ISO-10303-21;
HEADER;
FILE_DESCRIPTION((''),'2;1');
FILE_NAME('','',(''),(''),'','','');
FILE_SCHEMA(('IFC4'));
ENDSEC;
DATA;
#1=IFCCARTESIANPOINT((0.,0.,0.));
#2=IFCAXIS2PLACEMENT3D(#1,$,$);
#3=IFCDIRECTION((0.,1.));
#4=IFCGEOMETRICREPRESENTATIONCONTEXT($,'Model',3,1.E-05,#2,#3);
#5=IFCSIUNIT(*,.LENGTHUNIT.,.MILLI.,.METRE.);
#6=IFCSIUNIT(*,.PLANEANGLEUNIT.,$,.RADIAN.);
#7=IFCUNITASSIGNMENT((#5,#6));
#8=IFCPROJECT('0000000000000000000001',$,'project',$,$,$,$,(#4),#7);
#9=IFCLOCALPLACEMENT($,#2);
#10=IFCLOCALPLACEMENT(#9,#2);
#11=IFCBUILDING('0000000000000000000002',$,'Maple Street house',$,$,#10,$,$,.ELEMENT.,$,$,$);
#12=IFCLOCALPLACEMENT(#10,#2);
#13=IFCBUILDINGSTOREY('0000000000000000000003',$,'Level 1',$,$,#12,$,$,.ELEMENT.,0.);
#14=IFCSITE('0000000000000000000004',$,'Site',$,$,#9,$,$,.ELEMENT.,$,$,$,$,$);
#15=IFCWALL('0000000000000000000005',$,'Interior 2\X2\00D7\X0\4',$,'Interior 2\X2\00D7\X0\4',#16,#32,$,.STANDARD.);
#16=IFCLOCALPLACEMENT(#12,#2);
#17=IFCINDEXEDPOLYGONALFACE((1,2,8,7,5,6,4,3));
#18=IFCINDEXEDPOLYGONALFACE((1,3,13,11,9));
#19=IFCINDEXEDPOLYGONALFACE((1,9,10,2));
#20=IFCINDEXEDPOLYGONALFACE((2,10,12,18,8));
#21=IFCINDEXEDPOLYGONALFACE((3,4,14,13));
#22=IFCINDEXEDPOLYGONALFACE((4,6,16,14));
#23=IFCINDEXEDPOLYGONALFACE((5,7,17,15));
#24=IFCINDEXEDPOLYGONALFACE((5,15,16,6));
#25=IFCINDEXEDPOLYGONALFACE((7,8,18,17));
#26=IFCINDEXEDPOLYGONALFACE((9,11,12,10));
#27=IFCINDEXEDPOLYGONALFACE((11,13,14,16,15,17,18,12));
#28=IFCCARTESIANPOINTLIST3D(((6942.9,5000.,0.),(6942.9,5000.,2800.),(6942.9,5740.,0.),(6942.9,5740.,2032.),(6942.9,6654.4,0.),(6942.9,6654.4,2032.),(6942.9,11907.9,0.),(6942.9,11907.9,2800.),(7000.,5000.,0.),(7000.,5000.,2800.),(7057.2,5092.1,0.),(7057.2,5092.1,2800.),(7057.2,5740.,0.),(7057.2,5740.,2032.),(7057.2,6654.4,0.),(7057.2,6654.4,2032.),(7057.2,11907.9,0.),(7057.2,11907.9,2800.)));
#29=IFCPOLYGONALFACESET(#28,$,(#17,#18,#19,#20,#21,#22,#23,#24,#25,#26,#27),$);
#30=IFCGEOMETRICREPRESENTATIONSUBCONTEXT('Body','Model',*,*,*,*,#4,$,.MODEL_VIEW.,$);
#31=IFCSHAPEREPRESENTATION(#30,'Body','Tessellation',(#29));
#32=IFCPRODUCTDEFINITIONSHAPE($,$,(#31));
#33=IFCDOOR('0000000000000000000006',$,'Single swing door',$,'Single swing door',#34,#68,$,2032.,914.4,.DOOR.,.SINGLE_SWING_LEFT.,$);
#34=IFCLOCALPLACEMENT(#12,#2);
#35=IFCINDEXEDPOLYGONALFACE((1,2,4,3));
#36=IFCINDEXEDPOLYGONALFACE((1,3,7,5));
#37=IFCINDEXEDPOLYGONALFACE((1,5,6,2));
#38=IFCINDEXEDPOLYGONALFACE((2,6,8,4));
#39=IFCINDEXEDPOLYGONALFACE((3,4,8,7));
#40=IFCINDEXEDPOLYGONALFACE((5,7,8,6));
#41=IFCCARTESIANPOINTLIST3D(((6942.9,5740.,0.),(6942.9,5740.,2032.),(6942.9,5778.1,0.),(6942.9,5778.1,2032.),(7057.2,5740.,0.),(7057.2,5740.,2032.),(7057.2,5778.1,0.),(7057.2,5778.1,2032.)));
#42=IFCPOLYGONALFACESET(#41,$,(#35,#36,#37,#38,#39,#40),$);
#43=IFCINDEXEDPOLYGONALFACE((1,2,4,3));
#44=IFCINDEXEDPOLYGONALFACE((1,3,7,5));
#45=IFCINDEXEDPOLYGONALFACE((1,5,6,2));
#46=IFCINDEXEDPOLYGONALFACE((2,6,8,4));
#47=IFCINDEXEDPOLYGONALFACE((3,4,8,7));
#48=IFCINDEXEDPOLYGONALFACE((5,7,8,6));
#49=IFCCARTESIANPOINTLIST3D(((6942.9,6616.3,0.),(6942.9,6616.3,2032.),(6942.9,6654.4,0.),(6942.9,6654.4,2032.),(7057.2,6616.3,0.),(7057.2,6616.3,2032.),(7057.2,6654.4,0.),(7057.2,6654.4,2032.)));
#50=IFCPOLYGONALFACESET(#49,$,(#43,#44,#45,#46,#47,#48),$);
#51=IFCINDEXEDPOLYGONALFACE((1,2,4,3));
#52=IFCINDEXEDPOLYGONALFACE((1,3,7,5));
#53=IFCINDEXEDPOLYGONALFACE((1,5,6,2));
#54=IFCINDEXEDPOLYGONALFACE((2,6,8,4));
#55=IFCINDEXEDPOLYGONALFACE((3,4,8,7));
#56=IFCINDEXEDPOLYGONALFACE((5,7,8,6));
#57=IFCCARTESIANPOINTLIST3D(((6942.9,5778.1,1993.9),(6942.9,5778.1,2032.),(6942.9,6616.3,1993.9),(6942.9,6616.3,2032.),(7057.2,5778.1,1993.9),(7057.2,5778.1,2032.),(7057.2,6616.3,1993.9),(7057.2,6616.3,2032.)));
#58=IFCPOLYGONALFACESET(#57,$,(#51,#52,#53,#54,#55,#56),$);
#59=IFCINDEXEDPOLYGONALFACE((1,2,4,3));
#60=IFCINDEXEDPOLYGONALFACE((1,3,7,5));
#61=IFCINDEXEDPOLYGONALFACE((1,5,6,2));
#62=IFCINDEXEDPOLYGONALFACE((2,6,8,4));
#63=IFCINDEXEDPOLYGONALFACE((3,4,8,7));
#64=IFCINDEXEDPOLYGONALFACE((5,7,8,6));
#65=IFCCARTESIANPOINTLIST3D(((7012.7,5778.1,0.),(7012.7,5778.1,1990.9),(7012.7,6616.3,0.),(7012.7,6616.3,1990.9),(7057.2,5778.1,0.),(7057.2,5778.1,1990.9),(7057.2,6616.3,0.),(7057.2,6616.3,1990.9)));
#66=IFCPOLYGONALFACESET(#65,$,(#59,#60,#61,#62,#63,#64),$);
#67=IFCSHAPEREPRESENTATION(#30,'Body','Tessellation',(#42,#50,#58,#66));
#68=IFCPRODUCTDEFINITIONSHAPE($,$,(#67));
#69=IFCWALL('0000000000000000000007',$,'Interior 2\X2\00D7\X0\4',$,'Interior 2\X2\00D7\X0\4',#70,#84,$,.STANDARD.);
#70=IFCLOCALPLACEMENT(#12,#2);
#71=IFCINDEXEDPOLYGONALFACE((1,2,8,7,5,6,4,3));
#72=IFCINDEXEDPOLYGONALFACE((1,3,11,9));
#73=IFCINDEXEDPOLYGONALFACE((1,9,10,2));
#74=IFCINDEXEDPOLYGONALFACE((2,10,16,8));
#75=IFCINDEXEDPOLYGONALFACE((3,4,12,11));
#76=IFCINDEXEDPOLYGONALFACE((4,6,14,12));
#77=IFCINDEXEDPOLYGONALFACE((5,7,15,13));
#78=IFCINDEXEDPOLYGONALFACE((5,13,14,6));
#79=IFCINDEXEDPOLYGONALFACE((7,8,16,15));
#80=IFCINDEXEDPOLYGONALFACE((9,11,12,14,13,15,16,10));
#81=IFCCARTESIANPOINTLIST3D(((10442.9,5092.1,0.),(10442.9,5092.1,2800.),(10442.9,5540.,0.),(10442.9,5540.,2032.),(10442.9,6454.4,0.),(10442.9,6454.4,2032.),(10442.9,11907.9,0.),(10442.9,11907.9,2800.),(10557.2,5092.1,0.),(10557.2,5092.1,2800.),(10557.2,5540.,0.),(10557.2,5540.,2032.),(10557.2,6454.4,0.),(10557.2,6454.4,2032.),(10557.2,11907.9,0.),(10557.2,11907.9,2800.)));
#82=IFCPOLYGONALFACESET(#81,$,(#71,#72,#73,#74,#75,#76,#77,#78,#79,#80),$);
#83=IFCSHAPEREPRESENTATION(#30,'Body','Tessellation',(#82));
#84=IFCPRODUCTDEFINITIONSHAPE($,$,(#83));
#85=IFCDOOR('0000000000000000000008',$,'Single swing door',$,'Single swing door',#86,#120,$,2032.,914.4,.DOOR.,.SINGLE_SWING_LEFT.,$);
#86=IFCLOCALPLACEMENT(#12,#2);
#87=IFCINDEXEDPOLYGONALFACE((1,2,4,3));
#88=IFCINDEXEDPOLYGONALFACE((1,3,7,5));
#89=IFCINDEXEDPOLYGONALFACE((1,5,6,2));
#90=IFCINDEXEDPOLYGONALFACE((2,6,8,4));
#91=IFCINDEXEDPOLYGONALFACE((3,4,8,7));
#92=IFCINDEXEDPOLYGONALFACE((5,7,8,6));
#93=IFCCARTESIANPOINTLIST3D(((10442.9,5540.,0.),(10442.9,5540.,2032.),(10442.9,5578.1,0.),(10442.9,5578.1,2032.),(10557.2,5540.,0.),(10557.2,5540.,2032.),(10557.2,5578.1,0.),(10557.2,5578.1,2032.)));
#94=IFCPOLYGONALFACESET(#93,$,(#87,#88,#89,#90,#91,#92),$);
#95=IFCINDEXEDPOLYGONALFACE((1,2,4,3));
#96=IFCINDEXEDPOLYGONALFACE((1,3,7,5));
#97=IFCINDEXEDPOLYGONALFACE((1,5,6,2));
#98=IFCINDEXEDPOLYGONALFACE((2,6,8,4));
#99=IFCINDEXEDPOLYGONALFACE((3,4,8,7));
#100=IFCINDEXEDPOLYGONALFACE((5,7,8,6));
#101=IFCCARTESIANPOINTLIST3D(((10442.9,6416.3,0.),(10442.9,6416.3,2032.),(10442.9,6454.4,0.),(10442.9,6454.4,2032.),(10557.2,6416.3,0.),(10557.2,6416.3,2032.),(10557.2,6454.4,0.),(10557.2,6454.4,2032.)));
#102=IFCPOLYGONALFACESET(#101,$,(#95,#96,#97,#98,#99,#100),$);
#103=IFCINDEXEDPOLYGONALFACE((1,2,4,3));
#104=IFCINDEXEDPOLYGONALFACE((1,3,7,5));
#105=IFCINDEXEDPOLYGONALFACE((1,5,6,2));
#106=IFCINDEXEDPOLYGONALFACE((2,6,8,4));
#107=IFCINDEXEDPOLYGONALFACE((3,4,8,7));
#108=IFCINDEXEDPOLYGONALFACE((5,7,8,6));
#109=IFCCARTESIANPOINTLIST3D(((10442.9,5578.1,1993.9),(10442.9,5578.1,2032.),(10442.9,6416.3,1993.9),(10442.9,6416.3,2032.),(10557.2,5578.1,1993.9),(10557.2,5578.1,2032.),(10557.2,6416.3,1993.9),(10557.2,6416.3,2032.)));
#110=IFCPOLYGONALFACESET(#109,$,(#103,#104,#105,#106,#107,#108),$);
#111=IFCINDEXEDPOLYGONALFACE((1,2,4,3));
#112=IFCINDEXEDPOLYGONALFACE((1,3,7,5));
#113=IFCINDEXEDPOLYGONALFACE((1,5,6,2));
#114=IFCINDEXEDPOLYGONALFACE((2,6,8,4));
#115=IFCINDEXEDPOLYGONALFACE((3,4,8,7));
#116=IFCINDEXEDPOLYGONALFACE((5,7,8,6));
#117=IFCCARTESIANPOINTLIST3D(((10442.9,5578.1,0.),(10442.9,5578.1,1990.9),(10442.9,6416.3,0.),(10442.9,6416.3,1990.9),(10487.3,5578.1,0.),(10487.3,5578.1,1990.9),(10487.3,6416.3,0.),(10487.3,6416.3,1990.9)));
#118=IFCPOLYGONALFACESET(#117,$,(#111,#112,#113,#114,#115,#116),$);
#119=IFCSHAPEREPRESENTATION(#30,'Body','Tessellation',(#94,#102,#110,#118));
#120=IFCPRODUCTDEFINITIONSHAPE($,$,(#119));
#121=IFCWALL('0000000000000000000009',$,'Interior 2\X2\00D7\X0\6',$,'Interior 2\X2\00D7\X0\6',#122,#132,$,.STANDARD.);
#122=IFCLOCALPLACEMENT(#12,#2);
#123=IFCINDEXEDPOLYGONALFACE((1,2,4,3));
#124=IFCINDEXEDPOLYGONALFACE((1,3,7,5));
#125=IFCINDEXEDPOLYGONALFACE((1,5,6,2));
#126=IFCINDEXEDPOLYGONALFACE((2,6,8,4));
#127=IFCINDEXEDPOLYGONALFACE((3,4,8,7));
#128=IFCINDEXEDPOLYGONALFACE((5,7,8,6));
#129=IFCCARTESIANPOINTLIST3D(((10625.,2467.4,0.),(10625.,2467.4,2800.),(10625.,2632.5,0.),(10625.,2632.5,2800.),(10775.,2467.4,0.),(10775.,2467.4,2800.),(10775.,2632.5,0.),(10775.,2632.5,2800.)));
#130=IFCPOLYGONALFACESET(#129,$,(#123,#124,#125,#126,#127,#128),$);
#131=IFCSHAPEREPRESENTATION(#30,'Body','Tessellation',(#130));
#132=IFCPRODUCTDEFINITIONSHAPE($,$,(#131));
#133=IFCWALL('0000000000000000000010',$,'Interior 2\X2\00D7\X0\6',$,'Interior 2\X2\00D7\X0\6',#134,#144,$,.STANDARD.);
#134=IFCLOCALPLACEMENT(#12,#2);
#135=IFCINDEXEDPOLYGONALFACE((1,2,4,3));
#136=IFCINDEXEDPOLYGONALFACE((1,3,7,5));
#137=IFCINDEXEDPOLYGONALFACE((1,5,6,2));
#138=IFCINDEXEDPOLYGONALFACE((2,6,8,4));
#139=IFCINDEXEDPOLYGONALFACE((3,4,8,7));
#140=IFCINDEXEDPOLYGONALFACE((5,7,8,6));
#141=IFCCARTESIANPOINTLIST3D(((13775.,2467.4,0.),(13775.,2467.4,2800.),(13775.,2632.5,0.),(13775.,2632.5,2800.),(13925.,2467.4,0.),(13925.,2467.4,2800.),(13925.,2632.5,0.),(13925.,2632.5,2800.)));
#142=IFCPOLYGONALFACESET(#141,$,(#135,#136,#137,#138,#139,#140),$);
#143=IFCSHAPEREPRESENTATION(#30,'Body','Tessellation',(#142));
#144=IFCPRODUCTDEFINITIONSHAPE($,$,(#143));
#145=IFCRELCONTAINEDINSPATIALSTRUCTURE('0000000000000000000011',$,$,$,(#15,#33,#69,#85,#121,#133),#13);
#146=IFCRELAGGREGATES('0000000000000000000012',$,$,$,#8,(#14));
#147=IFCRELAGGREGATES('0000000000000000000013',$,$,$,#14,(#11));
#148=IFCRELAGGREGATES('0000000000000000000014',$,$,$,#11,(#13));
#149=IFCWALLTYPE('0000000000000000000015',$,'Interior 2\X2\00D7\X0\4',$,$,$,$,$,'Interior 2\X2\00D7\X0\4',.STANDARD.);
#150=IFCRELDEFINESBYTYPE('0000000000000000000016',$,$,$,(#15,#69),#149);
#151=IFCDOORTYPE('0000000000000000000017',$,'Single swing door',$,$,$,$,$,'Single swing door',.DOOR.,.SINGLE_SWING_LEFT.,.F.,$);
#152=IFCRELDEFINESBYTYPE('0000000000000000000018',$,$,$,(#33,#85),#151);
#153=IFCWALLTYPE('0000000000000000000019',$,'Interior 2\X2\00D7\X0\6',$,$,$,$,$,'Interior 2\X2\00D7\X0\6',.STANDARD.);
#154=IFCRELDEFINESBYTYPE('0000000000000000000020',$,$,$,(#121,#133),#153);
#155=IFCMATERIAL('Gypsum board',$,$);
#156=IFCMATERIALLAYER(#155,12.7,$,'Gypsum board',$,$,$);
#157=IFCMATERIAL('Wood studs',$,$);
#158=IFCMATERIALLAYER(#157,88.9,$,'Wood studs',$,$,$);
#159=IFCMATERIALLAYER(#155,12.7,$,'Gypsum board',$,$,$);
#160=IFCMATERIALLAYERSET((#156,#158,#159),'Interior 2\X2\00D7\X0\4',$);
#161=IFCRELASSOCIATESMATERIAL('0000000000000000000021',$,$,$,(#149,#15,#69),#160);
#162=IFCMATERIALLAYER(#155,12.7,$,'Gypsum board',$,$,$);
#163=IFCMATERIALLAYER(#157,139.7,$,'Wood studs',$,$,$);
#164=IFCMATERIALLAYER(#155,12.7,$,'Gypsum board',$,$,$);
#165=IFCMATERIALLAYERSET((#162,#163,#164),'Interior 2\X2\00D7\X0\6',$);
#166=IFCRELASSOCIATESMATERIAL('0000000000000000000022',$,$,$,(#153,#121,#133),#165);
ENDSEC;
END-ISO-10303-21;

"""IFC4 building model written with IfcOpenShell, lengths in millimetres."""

from ifc_helpers import new_model, si_unit, direction, frame, origin, origin_with_axes, place, context, subcontext, project, spatial, polyline, outline, extrude, material, layer, layer_set, layer_usage, type_object, element, fill, save


model = new_model("IFC4")

# Units and contexts
model_context = context("Model", 3, precision=1e-05, world=origin(), true_north=direction((0.0, 1.0)))
body_context = subcontext(model_context, "Body", "Model", "MODEL_VIEW")
ifc_project = project(units=[si_unit("LENGTHUNIT", "METRE", prefix="MILLI"), si_unit("PLANEANGLEUNIT", "RADIAN")], contexts=[model_context])

# Site, building, storey
site_placement = place(None, origin())
site = spatial("IfcSite", under=ifc_project, at=site_placement, Name="Site", CompositionType="ELEMENT")
building_placement = place(site_placement, origin())
building = spatial("IfcBuilding", under=site, at=building_placement, Name="Maple Street house", CompositionType="ELEMENT")
storey_placement = place(building_placement, origin())
storey = spatial("IfcBuildingStorey", under=building, at=storey_placement, Name="Level 1", CompositionType="ELEMENT", Elevation=0.0)

# Shared definitions
ifc_material_1 = material(Name="Wood studs")
ifc_material_2 = material(Name="Gypsum board")

# Walls, openings, doors
ifc_layer_1 = layer(ifc_material_2, 12.7, Name="Gypsum board")
ifc_layer_2 = layer(ifc_material_1, 88.9, Name="Wood studs")
ifc_layer_3 = layer(ifc_material_2, 12.7, Name="Gypsum board")
ifc_layer_set_1 = layer_set([ifc_layer_1, ifc_layer_2, ifc_layer_3], Name="Interior 2×4")
ifc_layer_usage_1 = layer_usage(ifc_layer_set_1, "AXIS2", "NEGATIVE", 57.1)
wall_type_1 = type_object("IfcWallType", Name="Interior 2×4", ElementType="Interior 2×4", PredefinedType="STANDARD", material=ifc_layer_set_1)
wall_1_placement = place(storey_placement, frame((7000.0, 5000.0, 0.0), z_axis=(0.0, 0.0, 1.0), x_axis=(0.0, 1.0, 0.0)))
wall_1 = element("IfcWall", 1, at=wall_1_placement, inside=storey, type_object=wall_type_1, material=ifc_layer_usage_1, Name="Interior 2×4", ObjectType="Interior 2×4", PredefinedType="STANDARD", context=body_context, shape_type="SweptSolid", body=[
    extrude(outline(polyline([(92.1, -57.1), (6907.9, -57.1), (6907.9, 57.1), (0.0, 57.1), (0.0, 0.0), (92.1, -57.1)])), origin(), (0.0, 0.0, 1.0), 2800.0),
])
opening_1_placement = place(wall_1_placement, frame((740.0, 0.0, 0.0), z_axis=(0.0, 0.0, 1.0), x_axis=(1.0, 0.0, 0.0)))
opening_1 = element("IfcOpeningElement", 2, at=opening_1_placement, cuts=wall_1, PredefinedType="OPENING", context=body_context, shape_type="SweptSolid", body=[
    extrude(outline(polyline([(0.0, -67.2), (914.4, -67.2), (914.4, 67.2), (0.0, 67.2), (0.0, -67.2)])), origin(), (0.0, 0.0, 1.0), 2032.0),
])
door_type_1 = type_object("IfcDoorType", Name="Single swing door", ElementType="Single swing door", OperationType="SINGLE_SWING_LEFT", ParameterTakesPrecedence=False, PredefinedType="DOOR")
door_1_placement = place(opening_1_placement, origin_with_axes())
door_1 = element("IfcDoor", 3, at=door_1_placement, inside=storey, type_object=door_type_1, Name="Single swing door", ObjectType="Single swing door", OperationType="SINGLE_SWING_LEFT", OverallHeight=2032.0, OverallWidth=914.4, PredefinedType="DOOR", context=body_context, shape_type="SweptSolid", body=[
    extrude(outline(polyline([(0.0, -57.1), (38.1, -57.1), (38.1, 57.1), (0.0, 57.1), (0.0, -57.1)])), origin(), (0.0, 0.0, 1.0), 2032.0),
    extrude(outline(polyline([(876.3, -57.1), (914.4, -57.1), (914.4, 57.1), (876.3, 57.1), (876.3, -57.1)])), origin(), (0.0, 0.0, 1.0), 2032.0),
    extrude(outline(polyline([(38.1, -57.1), (876.3, -57.1), (876.3, 57.1), (38.1, 57.1), (38.1, -57.1)])), frame((0.0, 0.0, 1993.9)), (0.0, 0.0, 1.0), 38.1),
    extrude(outline(polyline([(38.1, -57.1), (876.3, -57.1), (876.3, -12.7), (38.1, -12.7), (38.1, -57.1)])), origin(), (0.0, 0.0, 1.0), 1990.9),
])
fill(opening_1, door_1)
ifc_layer_usage_2 = layer_usage(ifc_layer_set_1, "AXIS2", "NEGATIVE", 57.1)
wall_2_placement = place(storey_placement, frame((10500.0, 5000.0, 0.0), z_axis=(0.0, 0.0, 1.0), x_axis=(0.0, 1.0, 0.0)))
wall_2 = element("IfcWall", 4, at=wall_2_placement, inside=storey, type_object=wall_type_1, material=ifc_layer_usage_2, Name="Interior 2×4", ObjectType="Interior 2×4", PredefinedType="STANDARD", context=body_context, shape_type="SweptSolid", body=[
    extrude(outline(polyline([(92.1, -57.1), (6907.9, -57.1), (6907.9, 57.1), (92.1, 57.1), (92.1, -57.1)])), origin(), (0.0, 0.0, 1.0), 2800.0),
])
opening_2_placement = place(wall_2_placement, frame((540.0, 0.0, 0.0), z_axis=(0.0, 0.0, 1.0), x_axis=(1.0, 0.0, 0.0)))
opening_2 = element("IfcOpeningElement", 5, at=opening_2_placement, cuts=wall_2, PredefinedType="OPENING", context=body_context, shape_type="SweptSolid", body=[
    extrude(outline(polyline([(0.0, -67.2), (914.4, -67.2), (914.4, 67.2), (0.0, 67.2), (0.0, -67.2)])), origin(), (0.0, 0.0, 1.0), 2032.0),
])
door_2_placement = place(opening_2_placement, origin_with_axes())
door_2 = element("IfcDoor", 6, at=door_2_placement, inside=storey, type_object=door_type_1, Name="Single swing door", ObjectType="Single swing door", OperationType="SINGLE_SWING_LEFT", OverallHeight=2032.0, OverallWidth=914.4, PredefinedType="DOOR", context=body_context, shape_type="SweptSolid", body=[
    extrude(outline(polyline([(0.0, -57.1), (38.1, -57.1), (38.1, 57.1), (0.0, 57.1), (0.0, -57.1)])), origin(), (0.0, 0.0, 1.0), 2032.0),
    extrude(outline(polyline([(876.3, -57.1), (914.4, -57.1), (914.4, 57.1), (876.3, 57.1), (876.3, -57.1)])), origin(), (0.0, 0.0, 1.0), 2032.0),
    extrude(outline(polyline([(38.1, -57.1), (876.3, -57.1), (876.3, 57.1), (38.1, 57.1), (38.1, -57.1)])), frame((0.0, 0.0, 1993.9)), (0.0, 0.0, 1.0), 38.1),
    extrude(outline(polyline([(38.1, 12.7), (876.3, 12.7), (876.3, 57.1), (38.1, 57.1), (38.1, 12.7)])), origin(), (0.0, 0.0, 1.0), 1990.9),
])
fill(opening_2, door_2)

# Walls
ifc_layer_4 = layer(ifc_material_2, 12.7, Name="Gypsum board")
ifc_layer_5 = layer(ifc_material_1, 139.7, Name="Wood studs")
ifc_layer_6 = layer(ifc_material_2, 12.7, Name="Gypsum board")
ifc_layer_set_2 = layer_set([ifc_layer_4, ifc_layer_5, ifc_layer_6], Name="Interior 2×6")
wall_type_2 = type_object("IfcWallType", Name="Interior 2×6", ElementType="Interior 2×6", PredefinedType="STANDARD", material=ifc_layer_set_2)
ifc_layer_usage_3 = layer_usage(ifc_layer_set_2, "AXIS2", "NEGATIVE", 82.5)
wall_3_placement = place(storey_placement, frame((10625.0, 2550.0, 0.0), z_axis=(0.0, 0.0, 1.0), x_axis=(1.0, 0.0, 0.0)))
element("IfcWall", 7, at=wall_3_placement, inside=storey, type_object=wall_type_2, material=ifc_layer_usage_3, Name="Interior 2×6", ObjectType="Interior 2×6", PredefinedType="STANDARD", context=body_context, shape_type="SweptSolid", body=[
    extrude(outline(polyline([(0.0, -82.5), (150.0, -82.5), (150.0, 82.5), (0.0, 82.5), (0.0, -82.5)])), origin(), (0.0, 0.0, 1.0), 2800.0),
])
ifc_layer_usage_4 = layer_usage(ifc_layer_set_2, "AXIS2", "NEGATIVE", 82.5)
wall_4_placement = place(storey_placement, frame((13775.0, 2550.0, 0.0), z_axis=(0.0, 0.0, 1.0), x_axis=(1.0, 0.0, 0.0)))
element("IfcWall", 8, at=wall_4_placement, inside=storey, type_object=wall_type_2, material=ifc_layer_usage_4, Name="Interior 2×6", ObjectType="Interior 2×6", PredefinedType="STANDARD", context=body_context, shape_type="SweptSolid", body=[
    extrude(outline(polyline([(0.0, -82.5), (150.0, -82.5), (150.0, 82.5), (0.0, 82.5), (0.0, -82.5)])), origin(), (0.0, 0.0, 1.0), 2800.0),
])

save(model, "model.ifc")
